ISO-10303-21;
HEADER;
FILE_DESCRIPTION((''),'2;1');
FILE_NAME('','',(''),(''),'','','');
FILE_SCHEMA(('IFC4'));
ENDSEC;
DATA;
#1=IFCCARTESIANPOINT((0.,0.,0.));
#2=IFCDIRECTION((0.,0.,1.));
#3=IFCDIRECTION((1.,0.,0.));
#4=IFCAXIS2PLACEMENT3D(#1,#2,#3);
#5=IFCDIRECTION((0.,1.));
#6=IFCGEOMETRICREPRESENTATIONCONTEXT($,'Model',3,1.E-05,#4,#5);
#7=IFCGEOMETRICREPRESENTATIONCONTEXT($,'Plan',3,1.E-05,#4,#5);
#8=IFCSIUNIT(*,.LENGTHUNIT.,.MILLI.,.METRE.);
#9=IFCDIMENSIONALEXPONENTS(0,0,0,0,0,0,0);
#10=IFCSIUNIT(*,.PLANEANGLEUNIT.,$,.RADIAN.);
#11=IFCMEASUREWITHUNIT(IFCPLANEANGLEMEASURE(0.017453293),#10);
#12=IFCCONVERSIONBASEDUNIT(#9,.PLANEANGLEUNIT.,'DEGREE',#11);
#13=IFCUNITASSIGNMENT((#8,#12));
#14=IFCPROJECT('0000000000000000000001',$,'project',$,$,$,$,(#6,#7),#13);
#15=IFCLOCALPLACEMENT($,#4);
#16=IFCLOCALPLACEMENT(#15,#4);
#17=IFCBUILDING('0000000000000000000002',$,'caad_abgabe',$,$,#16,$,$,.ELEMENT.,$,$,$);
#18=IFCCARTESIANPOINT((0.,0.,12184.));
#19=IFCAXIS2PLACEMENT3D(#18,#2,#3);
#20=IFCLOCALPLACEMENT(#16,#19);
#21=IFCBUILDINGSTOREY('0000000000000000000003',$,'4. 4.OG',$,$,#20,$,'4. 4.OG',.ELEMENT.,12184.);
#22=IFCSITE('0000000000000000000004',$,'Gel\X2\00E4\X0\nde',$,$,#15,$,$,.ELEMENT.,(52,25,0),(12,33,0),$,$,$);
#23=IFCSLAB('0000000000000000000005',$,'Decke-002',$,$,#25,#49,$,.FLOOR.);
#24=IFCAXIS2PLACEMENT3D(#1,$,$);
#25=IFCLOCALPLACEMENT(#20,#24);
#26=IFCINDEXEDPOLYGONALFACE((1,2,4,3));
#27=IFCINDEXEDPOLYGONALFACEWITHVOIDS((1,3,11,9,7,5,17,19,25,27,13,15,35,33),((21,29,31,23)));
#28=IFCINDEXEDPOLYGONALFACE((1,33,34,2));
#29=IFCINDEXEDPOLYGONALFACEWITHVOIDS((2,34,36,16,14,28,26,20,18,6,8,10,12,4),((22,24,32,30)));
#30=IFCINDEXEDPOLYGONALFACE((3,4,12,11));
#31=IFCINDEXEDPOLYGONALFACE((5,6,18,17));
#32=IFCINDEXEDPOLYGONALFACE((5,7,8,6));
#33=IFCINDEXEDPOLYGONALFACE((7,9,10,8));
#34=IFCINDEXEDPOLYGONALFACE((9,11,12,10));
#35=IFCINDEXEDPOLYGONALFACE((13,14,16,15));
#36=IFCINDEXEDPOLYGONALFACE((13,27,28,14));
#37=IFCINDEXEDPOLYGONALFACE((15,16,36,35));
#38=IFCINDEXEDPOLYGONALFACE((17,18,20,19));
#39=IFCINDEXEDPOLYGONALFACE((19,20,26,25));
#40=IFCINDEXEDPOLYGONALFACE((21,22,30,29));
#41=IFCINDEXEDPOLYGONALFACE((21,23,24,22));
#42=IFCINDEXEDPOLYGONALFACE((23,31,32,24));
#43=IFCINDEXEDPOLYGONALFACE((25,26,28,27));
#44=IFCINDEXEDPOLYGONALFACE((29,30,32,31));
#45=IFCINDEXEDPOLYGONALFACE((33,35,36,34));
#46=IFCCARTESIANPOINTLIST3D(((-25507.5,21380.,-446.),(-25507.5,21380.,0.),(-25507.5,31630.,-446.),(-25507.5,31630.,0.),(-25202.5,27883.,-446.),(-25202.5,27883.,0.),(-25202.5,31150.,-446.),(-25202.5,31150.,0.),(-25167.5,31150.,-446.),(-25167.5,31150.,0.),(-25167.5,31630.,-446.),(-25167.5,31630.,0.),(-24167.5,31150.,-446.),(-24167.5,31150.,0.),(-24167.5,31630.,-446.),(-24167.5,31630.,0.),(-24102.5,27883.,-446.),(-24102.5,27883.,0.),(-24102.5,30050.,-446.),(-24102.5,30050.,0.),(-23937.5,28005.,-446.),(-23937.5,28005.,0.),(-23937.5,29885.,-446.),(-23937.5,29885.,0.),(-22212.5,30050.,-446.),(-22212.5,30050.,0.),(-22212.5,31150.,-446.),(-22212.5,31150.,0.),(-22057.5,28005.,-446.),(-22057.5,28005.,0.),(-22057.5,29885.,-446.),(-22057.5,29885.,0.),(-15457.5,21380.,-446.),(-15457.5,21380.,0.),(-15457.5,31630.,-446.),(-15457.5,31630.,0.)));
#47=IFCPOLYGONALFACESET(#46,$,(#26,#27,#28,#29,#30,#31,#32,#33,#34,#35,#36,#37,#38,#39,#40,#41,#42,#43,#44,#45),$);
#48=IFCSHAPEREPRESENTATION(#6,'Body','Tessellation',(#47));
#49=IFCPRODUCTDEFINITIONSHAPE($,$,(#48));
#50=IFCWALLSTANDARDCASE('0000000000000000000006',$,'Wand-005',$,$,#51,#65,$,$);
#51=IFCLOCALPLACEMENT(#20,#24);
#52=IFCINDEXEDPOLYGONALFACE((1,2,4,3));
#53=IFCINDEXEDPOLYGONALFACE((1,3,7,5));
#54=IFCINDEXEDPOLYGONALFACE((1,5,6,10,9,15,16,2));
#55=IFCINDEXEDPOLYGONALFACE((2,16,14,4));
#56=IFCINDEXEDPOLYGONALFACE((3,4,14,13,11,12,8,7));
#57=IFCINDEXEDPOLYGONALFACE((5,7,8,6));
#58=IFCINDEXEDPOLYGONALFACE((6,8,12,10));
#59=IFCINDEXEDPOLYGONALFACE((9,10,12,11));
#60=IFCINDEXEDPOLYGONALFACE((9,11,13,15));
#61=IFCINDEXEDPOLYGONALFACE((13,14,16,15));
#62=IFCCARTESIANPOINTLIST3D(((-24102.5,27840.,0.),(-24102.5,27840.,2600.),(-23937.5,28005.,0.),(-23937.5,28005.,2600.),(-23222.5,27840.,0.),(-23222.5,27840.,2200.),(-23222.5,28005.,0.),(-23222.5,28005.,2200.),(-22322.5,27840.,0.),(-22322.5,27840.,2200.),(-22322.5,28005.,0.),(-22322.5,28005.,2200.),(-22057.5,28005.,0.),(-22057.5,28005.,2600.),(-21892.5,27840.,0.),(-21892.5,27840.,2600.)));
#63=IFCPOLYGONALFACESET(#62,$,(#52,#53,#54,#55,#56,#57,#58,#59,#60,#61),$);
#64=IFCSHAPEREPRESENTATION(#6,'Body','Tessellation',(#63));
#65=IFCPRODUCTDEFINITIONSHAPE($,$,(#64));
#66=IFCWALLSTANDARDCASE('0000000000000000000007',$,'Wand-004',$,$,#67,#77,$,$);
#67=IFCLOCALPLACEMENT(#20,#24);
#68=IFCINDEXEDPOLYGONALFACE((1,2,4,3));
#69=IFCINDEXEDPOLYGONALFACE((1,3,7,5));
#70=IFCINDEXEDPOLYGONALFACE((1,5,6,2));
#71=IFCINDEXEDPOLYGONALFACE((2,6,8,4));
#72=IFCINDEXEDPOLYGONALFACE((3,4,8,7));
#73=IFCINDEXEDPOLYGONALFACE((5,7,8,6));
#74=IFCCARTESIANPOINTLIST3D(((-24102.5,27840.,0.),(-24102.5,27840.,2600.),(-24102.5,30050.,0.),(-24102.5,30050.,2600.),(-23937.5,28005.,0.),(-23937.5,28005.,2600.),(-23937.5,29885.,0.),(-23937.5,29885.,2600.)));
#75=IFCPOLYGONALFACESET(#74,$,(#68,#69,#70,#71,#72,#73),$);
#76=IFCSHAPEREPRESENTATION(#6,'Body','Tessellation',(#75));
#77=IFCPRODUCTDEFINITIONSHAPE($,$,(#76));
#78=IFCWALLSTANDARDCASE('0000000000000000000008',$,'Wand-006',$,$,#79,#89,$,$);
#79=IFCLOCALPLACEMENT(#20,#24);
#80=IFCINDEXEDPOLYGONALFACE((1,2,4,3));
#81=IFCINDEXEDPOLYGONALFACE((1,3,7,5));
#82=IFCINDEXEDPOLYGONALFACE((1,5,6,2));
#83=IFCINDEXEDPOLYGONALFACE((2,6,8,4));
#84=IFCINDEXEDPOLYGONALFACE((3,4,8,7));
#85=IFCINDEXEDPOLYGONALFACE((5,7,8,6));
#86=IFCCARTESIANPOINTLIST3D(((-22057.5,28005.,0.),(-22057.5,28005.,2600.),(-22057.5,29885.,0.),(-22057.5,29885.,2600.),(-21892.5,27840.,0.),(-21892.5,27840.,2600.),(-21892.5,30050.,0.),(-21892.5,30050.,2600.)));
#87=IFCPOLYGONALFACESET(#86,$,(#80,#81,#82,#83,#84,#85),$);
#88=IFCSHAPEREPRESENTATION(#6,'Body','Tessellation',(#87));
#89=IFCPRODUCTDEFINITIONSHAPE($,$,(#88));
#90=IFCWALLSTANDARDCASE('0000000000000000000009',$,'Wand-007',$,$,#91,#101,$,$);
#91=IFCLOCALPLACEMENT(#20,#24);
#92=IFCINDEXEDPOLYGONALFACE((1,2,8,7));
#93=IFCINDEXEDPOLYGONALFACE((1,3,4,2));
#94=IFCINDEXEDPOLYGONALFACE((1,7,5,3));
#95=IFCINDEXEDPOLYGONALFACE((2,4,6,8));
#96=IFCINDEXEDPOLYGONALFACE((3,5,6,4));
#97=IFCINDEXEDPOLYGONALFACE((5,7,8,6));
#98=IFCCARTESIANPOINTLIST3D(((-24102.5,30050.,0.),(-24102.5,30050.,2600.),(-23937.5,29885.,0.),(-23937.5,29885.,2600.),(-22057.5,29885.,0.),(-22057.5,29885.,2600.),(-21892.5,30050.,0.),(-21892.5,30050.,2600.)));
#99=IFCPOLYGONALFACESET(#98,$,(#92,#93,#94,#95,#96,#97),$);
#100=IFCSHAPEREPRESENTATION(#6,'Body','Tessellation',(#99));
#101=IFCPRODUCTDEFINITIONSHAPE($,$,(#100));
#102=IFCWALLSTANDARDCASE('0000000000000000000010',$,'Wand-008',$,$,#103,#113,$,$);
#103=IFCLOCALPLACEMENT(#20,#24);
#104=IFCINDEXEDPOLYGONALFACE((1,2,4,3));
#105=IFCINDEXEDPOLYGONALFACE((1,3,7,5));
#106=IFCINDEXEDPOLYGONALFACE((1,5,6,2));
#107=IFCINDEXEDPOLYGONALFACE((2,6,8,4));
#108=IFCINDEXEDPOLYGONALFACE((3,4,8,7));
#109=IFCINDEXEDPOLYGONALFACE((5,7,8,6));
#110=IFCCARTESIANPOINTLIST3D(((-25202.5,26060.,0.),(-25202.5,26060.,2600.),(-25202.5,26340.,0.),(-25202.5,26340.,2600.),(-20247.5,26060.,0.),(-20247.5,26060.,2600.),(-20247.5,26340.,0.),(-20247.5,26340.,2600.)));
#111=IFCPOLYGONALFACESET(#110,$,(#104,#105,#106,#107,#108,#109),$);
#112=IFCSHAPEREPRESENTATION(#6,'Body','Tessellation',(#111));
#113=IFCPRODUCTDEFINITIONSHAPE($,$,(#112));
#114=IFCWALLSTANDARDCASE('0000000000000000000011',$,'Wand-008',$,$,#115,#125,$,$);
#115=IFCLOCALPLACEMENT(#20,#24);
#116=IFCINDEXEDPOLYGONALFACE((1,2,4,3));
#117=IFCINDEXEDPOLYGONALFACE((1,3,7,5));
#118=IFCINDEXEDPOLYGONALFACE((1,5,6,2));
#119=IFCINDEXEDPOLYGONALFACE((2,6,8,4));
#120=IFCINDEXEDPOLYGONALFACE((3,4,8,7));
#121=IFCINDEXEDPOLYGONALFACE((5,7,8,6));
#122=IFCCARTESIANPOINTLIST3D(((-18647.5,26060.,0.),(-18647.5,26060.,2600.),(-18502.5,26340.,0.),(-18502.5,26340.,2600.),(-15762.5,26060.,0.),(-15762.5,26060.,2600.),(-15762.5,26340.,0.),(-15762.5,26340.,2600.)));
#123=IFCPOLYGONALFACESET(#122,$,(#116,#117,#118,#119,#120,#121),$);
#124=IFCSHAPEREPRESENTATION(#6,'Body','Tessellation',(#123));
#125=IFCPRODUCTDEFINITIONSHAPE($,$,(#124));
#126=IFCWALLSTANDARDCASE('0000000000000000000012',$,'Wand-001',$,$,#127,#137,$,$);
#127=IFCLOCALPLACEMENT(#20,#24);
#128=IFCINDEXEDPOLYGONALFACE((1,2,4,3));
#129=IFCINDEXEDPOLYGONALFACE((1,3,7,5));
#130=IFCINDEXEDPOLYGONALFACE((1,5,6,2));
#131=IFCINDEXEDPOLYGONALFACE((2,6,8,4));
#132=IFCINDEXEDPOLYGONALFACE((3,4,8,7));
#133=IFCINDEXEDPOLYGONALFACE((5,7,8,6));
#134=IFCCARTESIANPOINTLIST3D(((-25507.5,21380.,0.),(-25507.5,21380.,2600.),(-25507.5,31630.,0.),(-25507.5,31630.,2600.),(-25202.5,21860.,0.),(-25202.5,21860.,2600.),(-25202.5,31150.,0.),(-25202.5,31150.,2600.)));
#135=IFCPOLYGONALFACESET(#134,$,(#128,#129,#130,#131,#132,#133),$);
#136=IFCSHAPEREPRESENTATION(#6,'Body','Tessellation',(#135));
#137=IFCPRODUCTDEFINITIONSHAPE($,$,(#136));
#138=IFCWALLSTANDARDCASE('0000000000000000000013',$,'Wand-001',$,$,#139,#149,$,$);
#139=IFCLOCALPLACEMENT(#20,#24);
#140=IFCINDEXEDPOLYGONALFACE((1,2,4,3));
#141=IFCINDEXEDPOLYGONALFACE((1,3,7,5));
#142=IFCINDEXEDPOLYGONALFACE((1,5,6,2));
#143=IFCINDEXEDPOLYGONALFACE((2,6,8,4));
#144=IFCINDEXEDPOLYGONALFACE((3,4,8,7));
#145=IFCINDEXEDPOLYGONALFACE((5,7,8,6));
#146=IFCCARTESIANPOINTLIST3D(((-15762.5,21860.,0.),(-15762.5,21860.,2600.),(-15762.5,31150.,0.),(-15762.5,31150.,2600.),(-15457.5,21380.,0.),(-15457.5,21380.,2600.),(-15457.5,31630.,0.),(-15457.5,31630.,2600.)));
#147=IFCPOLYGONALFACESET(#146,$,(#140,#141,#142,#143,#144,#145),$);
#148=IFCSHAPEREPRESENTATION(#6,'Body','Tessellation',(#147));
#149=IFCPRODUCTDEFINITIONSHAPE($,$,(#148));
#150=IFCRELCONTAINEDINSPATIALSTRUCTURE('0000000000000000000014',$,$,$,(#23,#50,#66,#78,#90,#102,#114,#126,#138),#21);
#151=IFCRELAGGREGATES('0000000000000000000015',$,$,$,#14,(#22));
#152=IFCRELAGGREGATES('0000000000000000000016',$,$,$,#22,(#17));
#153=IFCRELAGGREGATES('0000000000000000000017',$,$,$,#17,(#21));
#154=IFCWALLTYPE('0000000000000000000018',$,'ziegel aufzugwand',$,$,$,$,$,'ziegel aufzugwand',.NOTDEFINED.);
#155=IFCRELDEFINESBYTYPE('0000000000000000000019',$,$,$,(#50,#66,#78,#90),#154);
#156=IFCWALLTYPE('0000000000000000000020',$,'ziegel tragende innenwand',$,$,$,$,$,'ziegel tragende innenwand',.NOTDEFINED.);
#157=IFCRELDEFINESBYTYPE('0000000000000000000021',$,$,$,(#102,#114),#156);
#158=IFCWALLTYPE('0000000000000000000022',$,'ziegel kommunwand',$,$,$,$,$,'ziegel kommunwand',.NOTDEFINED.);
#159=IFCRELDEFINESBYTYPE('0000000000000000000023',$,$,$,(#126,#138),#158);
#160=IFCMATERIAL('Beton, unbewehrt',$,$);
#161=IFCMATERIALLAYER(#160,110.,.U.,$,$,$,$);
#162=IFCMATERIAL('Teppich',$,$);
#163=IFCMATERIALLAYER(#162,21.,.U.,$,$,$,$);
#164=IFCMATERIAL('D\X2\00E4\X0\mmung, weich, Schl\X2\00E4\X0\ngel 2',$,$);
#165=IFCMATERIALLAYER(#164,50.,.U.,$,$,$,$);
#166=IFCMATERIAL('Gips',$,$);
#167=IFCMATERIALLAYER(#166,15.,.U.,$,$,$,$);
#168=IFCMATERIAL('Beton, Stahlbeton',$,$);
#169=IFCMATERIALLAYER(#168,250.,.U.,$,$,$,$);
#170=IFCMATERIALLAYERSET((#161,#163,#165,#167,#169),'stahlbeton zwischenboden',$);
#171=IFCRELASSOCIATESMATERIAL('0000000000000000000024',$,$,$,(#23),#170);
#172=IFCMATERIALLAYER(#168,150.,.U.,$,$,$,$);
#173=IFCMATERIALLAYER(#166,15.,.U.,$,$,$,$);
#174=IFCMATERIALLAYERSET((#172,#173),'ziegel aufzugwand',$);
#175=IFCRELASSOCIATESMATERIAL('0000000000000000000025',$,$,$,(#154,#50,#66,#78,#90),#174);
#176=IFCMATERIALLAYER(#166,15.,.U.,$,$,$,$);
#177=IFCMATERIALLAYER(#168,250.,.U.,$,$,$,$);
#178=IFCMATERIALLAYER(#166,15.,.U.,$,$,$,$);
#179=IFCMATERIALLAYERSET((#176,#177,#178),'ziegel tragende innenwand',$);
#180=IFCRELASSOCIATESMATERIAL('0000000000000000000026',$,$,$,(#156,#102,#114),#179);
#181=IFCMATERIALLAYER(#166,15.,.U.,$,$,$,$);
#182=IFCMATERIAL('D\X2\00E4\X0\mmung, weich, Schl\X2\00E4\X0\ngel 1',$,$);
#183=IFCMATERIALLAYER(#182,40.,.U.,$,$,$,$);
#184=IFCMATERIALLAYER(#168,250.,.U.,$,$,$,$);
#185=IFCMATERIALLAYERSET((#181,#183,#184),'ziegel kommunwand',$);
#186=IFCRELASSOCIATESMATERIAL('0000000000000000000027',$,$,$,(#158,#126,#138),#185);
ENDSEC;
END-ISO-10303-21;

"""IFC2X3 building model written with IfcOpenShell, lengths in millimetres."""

from ifc_helpers import new_model, entity, si_unit, converted_unit, direction, frame, frame_2d, origin_with_axes, place, context, project, spatial, polyline, rectangle, outline, extrude, material, layer, layer_set, layer_usage, type_object, element, save


model = new_model("IFC2X3")

# Units and contexts
model_context = context("Model", 3, precision=1e-05, world=origin_with_axes(), true_north=direction((0.0, 1.0)))
plan_context = context("Plan", 3, precision=1e-05, world=origin_with_axes(), true_north=direction((0.0, 1.0)))
ifc_project = project(units=[si_unit("LENGTHUNIT", "METRE", prefix="MILLI"), converted_unit("PLANEANGLEUNIT", "DEGREE", entity("IfcPlaneAngleMeasure", 0.017453293), si_unit("PLANEANGLEUNIT", "RADIAN"), dimensions=[0, 0, 0, 0, 0, 0, 0])], contexts=[model_context, plan_context])

# Site, building, storey
site_placement = place(None, origin_with_axes())
site = spatial("IfcSite", under=ifc_project, at=site_placement, Name="Gelände", CompositionType="ELEMENT", RefLatitude=(52, 25, 0), RefLongitude=(12, 33, 0))
building_placement = place(site_placement, origin_with_axes())
building = spatial("IfcBuilding", under=site, at=building_placement, Name="caad_abgabe", CompositionType="ELEMENT")
storey_placement = place(building_placement, frame((0.0, 0.0, 12184.0), z_axis=(0.0, 0.0, 1.0), x_axis=(1.0, 0.0, 0.0)))
storey = spatial("IfcBuildingStorey", under=building, at=storey_placement, Name="4. 4.OG", LongName="4. 4.OG", CompositionType="ELEMENT", Elevation=12184.0)

# Slab, opening
ifc_material_1 = material(Name="Beton, unbewehrt")
ifc_layer_1 = layer(ifc_material_1, 110.0, ventilated="UNKNOWN")
ifc_material_2 = material(Name="Teppich")
ifc_layer_2 = layer(ifc_material_2, 21.0, ventilated="UNKNOWN")
ifc_material_3 = material(Name="Dämmung, weich, Schlängel 2")
ifc_layer_3 = layer(ifc_material_3, 50.0, ventilated="UNKNOWN")
ifc_material_4 = material(Name="Gips")
ifc_layer_4 = layer(ifc_material_4, 15.0, ventilated="UNKNOWN")
ifc_material_5 = material(Name="Beton, Stahlbeton")
ifc_layer_5 = layer(ifc_material_5, 250.0, ventilated="UNKNOWN")
ifc_layer_set_1 = layer_set([ifc_layer_1, ifc_layer_2, ifc_layer_3, ifc_layer_4, ifc_layer_5], Name="stahlbeton zwischenboden")
ifc_layer_usage_1 = layer_usage(ifc_layer_set_1, "AXIS3", "NEGATIVE", 446.0)
slab_placement = place(storey_placement, frame((-25507.5, 31630.0, -446.0), z_axis=(0.0, 0.0, 1.0), x_axis=(0.0, -1.0, 0.0)))
slab = element("IfcSlab", 1, at=slab_placement, inside=storey, material=ifc_layer_usage_1, Name="Decke-002", PredefinedType="FLOOR", context=model_context, shape_type="SweptSolid", body=[
    extrude(outline(polyline([(0.0, 0.0), (10250.0, 0.0), (10250.0, 10050.0), (0.0, 10050.0), (0.0, 1340.0), (480.0, 1340.0), (480.0, 3295.0), (1580.0, 3295.0), (1580.0, 1405.0), (3747.0, 1405.0), (3747.0, 305.0), (480.0, 305.0), (480.0, 340.0), (0.0, 340.0), (0.0, 0.0)])), origin_with_axes(), (0.0, 0.0, 1.0), 446.0),
])
opening_1_placement = place(slab_placement, origin_with_axes())
element("IfcOpeningElement", 2, at=opening_1_placement, cuts=slab, context=model_context, shape_type="SweptSolid", body=[
    extrude(outline(polyline([(3625.0, 1570.0), (1745.0, 1570.0), (1745.0, 3450.0), (3625.0, 3450.0), (3625.0, 1570.0)])), origin_with_axes(), (0.0, 0.0, 1.0), 446.0),
])

# Wall, opening
ifc_layer_6 = layer(ifc_material_5, 150.0, ventilated="UNKNOWN")
ifc_layer_7 = layer(ifc_material_4, 15.0, ventilated="UNKNOWN")
ifc_layer_set_2 = layer_set([ifc_layer_6, ifc_layer_7], Name="ziegel aufzugwand")
ifc_layer_usage_2 = layer_usage(ifc_layer_set_2, "AXIS2", "POSITIVE", 0.0)
wall_type_1 = type_object("IfcWallType", Name="ziegel aufzugwand", ElementType="ziegel aufzugwand", PredefinedType="NOTDEFINED", material=ifc_layer_set_2)
wall_1_placement = place(storey_placement, frame((-24102.5, 27840.0, 0.0), z_axis=(0.0, 0.0, 1.0), x_axis=(1.0, 0.0, 0.0)))
wall_1 = element("IfcWallStandardCase", 3, at=wall_1_placement, inside=storey, type_object=wall_type_1, material=ifc_layer_usage_2, Name="Wand-005", context=model_context, shape_type="SweptSolid", body=[
    extrude(outline(polyline([(0.0, 0.0), (2210.0, 0.0), (2045.0, 165.0), (165.0, 165.0), (0.0, 0.0)])), origin_with_axes(), (0.0, 0.0, 1.0), 2600.0),
])
opening_2_placement = place(wall_1_placement, frame((1330.0, 0.0, 0.0), z_axis=(0.0, 0.0, 1.0), x_axis=(1.0, 0.0, 0.0)))
element("IfcOpeningElement", 4, at=opening_2_placement, cuts=wall_1, ObjectType="Opening", context=model_context, shape_type="SweptSolid", body=[
    extrude(rectangle(XDim=900.0, YDim=2200.0, at=frame_2d((0.0, 1100.0), x_axis=(-1.0, 0.0))), frame((0.0, 0.0, 0.0), z_axis=(0.0, 1.0, 0.0), x_axis=(-1.0, 0.0, 0.0)), (0.0, 0.0, 1.0), 165.0),
])

# Walls
ifc_layer_usage_3 = layer_usage(ifc_layer_set_2, "AXIS2", "POSITIVE", 0.0)
wall_2_placement = place(storey_placement, frame((-24102.5, 30050.0, 0.0), z_axis=(0.0, 0.0, 1.0), x_axis=(0.0, -1.0, 0.0)))
element("IfcWallStandardCase", 5, at=wall_2_placement, inside=storey, type_object=wall_type_1, material=ifc_layer_usage_3, Name="Wand-004", context=model_context, shape_type="SweptSolid", body=[
    extrude(outline(polyline([(0.0, 0.0), (2210.0, 0.0), (2045.0, 165.0), (165.0, 165.0), (0.0, 0.0)])), origin_with_axes(), (0.0, 0.0, 1.0), 2600.0),
])
ifc_layer_usage_4 = layer_usage(ifc_layer_set_2, "AXIS2", "POSITIVE", 0.0)
wall_3_placement = place(storey_placement, frame((-21892.5, 27840.0, 0.0), z_axis=(0.0, 0.0, 1.0), x_axis=(0.0, 1.0, 0.0)))
element("IfcWallStandardCase", 6, at=wall_3_placement, inside=storey, type_object=wall_type_1, material=ifc_layer_usage_4, Name="Wand-006", context=model_context, shape_type="SweptSolid", body=[
    extrude(outline(polyline([(0.0, 0.0), (2210.0, 0.0), (2045.0, 165.0), (165.0, 165.0), (0.0, 0.0)])), origin_with_axes(), (0.0, 0.0, 1.0), 2600.0),
])
ifc_layer_usage_5 = layer_usage(ifc_layer_set_2, "AXIS2", "POSITIVE", 0.0)
wall_4_placement = place(storey_placement, frame((-21892.5, 30050.0, 0.0), z_axis=(0.0, 0.0, 1.0), x_axis=(-1.0, 0.0, 0.0)))
element("IfcWallStandardCase", 7, at=wall_4_placement, inside=storey, type_object=wall_type_1, material=ifc_layer_usage_5, Name="Wand-007", context=model_context, shape_type="SweptSolid", body=[
    extrude(outline(polyline([(0.0, 0.0), (2210.0, 0.0), (2045.0, 165.0), (165.0, 165.0), (0.0, 0.0)])), origin_with_axes(), (0.0, 0.0, 1.0), 2600.0),
])
ifc_layer_8 = layer(ifc_material_4, 15.0, ventilated="UNKNOWN")
ifc_layer_9 = layer(ifc_material_5, 250.0, ventilated="UNKNOWN")
ifc_layer_10 = layer(ifc_material_4, 15.0, ventilated="UNKNOWN")
ifc_layer_set_3 = layer_set([ifc_layer_8, ifc_layer_9, ifc_layer_10], Name="ziegel tragende innenwand")
ifc_layer_usage_6 = layer_usage(ifc_layer_set_3, "AXIS2", "NEGATIVE", 0.0)
wall_type_2 = type_object("IfcWallType", Name="ziegel tragende innenwand", ElementType="ziegel tragende innenwand", PredefinedType="NOTDEFINED", material=ifc_layer_set_3)
wall_5_placement = place(storey_placement, frame((-25202.5, 26340.0, 0.0), z_axis=(0.0, 0.0, 1.0), x_axis=(1.0, 0.0, 0.0)))
element("IfcWallStandardCase", 8, at=wall_5_placement, inside=storey, type_object=wall_type_2, material=ifc_layer_usage_6, Name="Wand-008", context=model_context, shape_type="SweptSolid", body=[
    extrude(outline(polyline([(0.0, -280.0), (4955.0, -280.0), (4955.0, 0.0), (0.0, 0.0), (0.0, -280.0)])), origin_with_axes(), (0.0, 0.0, 1.0), 2600.0),
])
ifc_layer_usage_7 = layer_usage(ifc_layer_set_3, "AXIS2", "NEGATIVE", 0.0)
wall_6_placement = place(storey_placement, frame((-18647.5, 26340.0, 0.0), z_axis=(0.0, 0.0, 1.0), x_axis=(1.0, 0.0, 0.0)))
element("IfcWallStandardCase", 9, at=wall_6_placement, inside=storey, type_object=wall_type_2, material=ifc_layer_usage_7, Name="Wand-008", context=model_context, shape_type="SweptSolid", body=[
    extrude(outline(polyline([(0.0, -280.0), (2885.0, -280.0), (2885.0, 0.0), (145.0, 0.0), (0.0, -280.0)])), origin_with_axes(), (0.0, 0.0, 1.0), 2600.0),
])
ifc_layer_11 = layer(ifc_material_4, 15.0, ventilated="UNKNOWN")
ifc_material_6 = material(Name="Dämmung, weich, Schlängel 1")
ifc_layer_12 = layer(ifc_material_6, 40.0, ventilated="UNKNOWN")
ifc_layer_13 = layer(ifc_material_5, 250.0, ventilated="UNKNOWN")
ifc_layer_set_4 = layer_set([ifc_layer_11, ifc_layer_12, ifc_layer_13], Name="ziegel kommunwand")
ifc_layer_usage_8 = layer_usage(ifc_layer_set_4, "AXIS2", "POSITIVE", 0.0)
wall_type_3 = type_object("IfcWallType", Name="ziegel kommunwand", ElementType="ziegel kommunwand", PredefinedType="NOTDEFINED", material=ifc_layer_set_4)
wall_7_placement = place(storey_placement, frame((-25507.5, 31630.0, 0.0), z_axis=(0.0, 0.0, 1.0), x_axis=(0.0, -1.0, 0.0)))
element("IfcWallStandardCase", 10, at=wall_7_placement, inside=storey, type_object=wall_type_3, material=ifc_layer_usage_8, Name="Wand-001", context=model_context, shape_type="SweptSolid", body=[
    extrude(outline(polyline([(0.0, 0.0), (10250.0, 0.0), (9770.0, 305.0), (480.0, 305.0), (0.0, 0.0)])), origin_with_axes(), (0.0, 0.0, 1.0), 2600.0),
])
ifc_layer_usage_9 = layer_usage(ifc_layer_set_4, "AXIS2", "NEGATIVE", 0.0)
wall_8_placement = place(storey_placement, frame((-15457.5, 31630.0, 0.0), z_axis=(0.0, 0.0, 1.0), x_axis=(0.0, -1.0, 0.0)))
element("IfcWallStandardCase", 11, at=wall_8_placement, inside=storey, type_object=wall_type_3, material=ifc_layer_usage_9, Name="Wand-001", context=model_context, shape_type="SweptSolid", body=[
    extrude(outline(polyline([(480.0, -305.0), (9770.0, -305.0), (10250.0, 0.0), (0.0, 0.0), (480.0, -305.0)])), origin_with_axes(), (0.0, 0.0, 1.0), 2600.0),
])

save(model, "model.ifc")
